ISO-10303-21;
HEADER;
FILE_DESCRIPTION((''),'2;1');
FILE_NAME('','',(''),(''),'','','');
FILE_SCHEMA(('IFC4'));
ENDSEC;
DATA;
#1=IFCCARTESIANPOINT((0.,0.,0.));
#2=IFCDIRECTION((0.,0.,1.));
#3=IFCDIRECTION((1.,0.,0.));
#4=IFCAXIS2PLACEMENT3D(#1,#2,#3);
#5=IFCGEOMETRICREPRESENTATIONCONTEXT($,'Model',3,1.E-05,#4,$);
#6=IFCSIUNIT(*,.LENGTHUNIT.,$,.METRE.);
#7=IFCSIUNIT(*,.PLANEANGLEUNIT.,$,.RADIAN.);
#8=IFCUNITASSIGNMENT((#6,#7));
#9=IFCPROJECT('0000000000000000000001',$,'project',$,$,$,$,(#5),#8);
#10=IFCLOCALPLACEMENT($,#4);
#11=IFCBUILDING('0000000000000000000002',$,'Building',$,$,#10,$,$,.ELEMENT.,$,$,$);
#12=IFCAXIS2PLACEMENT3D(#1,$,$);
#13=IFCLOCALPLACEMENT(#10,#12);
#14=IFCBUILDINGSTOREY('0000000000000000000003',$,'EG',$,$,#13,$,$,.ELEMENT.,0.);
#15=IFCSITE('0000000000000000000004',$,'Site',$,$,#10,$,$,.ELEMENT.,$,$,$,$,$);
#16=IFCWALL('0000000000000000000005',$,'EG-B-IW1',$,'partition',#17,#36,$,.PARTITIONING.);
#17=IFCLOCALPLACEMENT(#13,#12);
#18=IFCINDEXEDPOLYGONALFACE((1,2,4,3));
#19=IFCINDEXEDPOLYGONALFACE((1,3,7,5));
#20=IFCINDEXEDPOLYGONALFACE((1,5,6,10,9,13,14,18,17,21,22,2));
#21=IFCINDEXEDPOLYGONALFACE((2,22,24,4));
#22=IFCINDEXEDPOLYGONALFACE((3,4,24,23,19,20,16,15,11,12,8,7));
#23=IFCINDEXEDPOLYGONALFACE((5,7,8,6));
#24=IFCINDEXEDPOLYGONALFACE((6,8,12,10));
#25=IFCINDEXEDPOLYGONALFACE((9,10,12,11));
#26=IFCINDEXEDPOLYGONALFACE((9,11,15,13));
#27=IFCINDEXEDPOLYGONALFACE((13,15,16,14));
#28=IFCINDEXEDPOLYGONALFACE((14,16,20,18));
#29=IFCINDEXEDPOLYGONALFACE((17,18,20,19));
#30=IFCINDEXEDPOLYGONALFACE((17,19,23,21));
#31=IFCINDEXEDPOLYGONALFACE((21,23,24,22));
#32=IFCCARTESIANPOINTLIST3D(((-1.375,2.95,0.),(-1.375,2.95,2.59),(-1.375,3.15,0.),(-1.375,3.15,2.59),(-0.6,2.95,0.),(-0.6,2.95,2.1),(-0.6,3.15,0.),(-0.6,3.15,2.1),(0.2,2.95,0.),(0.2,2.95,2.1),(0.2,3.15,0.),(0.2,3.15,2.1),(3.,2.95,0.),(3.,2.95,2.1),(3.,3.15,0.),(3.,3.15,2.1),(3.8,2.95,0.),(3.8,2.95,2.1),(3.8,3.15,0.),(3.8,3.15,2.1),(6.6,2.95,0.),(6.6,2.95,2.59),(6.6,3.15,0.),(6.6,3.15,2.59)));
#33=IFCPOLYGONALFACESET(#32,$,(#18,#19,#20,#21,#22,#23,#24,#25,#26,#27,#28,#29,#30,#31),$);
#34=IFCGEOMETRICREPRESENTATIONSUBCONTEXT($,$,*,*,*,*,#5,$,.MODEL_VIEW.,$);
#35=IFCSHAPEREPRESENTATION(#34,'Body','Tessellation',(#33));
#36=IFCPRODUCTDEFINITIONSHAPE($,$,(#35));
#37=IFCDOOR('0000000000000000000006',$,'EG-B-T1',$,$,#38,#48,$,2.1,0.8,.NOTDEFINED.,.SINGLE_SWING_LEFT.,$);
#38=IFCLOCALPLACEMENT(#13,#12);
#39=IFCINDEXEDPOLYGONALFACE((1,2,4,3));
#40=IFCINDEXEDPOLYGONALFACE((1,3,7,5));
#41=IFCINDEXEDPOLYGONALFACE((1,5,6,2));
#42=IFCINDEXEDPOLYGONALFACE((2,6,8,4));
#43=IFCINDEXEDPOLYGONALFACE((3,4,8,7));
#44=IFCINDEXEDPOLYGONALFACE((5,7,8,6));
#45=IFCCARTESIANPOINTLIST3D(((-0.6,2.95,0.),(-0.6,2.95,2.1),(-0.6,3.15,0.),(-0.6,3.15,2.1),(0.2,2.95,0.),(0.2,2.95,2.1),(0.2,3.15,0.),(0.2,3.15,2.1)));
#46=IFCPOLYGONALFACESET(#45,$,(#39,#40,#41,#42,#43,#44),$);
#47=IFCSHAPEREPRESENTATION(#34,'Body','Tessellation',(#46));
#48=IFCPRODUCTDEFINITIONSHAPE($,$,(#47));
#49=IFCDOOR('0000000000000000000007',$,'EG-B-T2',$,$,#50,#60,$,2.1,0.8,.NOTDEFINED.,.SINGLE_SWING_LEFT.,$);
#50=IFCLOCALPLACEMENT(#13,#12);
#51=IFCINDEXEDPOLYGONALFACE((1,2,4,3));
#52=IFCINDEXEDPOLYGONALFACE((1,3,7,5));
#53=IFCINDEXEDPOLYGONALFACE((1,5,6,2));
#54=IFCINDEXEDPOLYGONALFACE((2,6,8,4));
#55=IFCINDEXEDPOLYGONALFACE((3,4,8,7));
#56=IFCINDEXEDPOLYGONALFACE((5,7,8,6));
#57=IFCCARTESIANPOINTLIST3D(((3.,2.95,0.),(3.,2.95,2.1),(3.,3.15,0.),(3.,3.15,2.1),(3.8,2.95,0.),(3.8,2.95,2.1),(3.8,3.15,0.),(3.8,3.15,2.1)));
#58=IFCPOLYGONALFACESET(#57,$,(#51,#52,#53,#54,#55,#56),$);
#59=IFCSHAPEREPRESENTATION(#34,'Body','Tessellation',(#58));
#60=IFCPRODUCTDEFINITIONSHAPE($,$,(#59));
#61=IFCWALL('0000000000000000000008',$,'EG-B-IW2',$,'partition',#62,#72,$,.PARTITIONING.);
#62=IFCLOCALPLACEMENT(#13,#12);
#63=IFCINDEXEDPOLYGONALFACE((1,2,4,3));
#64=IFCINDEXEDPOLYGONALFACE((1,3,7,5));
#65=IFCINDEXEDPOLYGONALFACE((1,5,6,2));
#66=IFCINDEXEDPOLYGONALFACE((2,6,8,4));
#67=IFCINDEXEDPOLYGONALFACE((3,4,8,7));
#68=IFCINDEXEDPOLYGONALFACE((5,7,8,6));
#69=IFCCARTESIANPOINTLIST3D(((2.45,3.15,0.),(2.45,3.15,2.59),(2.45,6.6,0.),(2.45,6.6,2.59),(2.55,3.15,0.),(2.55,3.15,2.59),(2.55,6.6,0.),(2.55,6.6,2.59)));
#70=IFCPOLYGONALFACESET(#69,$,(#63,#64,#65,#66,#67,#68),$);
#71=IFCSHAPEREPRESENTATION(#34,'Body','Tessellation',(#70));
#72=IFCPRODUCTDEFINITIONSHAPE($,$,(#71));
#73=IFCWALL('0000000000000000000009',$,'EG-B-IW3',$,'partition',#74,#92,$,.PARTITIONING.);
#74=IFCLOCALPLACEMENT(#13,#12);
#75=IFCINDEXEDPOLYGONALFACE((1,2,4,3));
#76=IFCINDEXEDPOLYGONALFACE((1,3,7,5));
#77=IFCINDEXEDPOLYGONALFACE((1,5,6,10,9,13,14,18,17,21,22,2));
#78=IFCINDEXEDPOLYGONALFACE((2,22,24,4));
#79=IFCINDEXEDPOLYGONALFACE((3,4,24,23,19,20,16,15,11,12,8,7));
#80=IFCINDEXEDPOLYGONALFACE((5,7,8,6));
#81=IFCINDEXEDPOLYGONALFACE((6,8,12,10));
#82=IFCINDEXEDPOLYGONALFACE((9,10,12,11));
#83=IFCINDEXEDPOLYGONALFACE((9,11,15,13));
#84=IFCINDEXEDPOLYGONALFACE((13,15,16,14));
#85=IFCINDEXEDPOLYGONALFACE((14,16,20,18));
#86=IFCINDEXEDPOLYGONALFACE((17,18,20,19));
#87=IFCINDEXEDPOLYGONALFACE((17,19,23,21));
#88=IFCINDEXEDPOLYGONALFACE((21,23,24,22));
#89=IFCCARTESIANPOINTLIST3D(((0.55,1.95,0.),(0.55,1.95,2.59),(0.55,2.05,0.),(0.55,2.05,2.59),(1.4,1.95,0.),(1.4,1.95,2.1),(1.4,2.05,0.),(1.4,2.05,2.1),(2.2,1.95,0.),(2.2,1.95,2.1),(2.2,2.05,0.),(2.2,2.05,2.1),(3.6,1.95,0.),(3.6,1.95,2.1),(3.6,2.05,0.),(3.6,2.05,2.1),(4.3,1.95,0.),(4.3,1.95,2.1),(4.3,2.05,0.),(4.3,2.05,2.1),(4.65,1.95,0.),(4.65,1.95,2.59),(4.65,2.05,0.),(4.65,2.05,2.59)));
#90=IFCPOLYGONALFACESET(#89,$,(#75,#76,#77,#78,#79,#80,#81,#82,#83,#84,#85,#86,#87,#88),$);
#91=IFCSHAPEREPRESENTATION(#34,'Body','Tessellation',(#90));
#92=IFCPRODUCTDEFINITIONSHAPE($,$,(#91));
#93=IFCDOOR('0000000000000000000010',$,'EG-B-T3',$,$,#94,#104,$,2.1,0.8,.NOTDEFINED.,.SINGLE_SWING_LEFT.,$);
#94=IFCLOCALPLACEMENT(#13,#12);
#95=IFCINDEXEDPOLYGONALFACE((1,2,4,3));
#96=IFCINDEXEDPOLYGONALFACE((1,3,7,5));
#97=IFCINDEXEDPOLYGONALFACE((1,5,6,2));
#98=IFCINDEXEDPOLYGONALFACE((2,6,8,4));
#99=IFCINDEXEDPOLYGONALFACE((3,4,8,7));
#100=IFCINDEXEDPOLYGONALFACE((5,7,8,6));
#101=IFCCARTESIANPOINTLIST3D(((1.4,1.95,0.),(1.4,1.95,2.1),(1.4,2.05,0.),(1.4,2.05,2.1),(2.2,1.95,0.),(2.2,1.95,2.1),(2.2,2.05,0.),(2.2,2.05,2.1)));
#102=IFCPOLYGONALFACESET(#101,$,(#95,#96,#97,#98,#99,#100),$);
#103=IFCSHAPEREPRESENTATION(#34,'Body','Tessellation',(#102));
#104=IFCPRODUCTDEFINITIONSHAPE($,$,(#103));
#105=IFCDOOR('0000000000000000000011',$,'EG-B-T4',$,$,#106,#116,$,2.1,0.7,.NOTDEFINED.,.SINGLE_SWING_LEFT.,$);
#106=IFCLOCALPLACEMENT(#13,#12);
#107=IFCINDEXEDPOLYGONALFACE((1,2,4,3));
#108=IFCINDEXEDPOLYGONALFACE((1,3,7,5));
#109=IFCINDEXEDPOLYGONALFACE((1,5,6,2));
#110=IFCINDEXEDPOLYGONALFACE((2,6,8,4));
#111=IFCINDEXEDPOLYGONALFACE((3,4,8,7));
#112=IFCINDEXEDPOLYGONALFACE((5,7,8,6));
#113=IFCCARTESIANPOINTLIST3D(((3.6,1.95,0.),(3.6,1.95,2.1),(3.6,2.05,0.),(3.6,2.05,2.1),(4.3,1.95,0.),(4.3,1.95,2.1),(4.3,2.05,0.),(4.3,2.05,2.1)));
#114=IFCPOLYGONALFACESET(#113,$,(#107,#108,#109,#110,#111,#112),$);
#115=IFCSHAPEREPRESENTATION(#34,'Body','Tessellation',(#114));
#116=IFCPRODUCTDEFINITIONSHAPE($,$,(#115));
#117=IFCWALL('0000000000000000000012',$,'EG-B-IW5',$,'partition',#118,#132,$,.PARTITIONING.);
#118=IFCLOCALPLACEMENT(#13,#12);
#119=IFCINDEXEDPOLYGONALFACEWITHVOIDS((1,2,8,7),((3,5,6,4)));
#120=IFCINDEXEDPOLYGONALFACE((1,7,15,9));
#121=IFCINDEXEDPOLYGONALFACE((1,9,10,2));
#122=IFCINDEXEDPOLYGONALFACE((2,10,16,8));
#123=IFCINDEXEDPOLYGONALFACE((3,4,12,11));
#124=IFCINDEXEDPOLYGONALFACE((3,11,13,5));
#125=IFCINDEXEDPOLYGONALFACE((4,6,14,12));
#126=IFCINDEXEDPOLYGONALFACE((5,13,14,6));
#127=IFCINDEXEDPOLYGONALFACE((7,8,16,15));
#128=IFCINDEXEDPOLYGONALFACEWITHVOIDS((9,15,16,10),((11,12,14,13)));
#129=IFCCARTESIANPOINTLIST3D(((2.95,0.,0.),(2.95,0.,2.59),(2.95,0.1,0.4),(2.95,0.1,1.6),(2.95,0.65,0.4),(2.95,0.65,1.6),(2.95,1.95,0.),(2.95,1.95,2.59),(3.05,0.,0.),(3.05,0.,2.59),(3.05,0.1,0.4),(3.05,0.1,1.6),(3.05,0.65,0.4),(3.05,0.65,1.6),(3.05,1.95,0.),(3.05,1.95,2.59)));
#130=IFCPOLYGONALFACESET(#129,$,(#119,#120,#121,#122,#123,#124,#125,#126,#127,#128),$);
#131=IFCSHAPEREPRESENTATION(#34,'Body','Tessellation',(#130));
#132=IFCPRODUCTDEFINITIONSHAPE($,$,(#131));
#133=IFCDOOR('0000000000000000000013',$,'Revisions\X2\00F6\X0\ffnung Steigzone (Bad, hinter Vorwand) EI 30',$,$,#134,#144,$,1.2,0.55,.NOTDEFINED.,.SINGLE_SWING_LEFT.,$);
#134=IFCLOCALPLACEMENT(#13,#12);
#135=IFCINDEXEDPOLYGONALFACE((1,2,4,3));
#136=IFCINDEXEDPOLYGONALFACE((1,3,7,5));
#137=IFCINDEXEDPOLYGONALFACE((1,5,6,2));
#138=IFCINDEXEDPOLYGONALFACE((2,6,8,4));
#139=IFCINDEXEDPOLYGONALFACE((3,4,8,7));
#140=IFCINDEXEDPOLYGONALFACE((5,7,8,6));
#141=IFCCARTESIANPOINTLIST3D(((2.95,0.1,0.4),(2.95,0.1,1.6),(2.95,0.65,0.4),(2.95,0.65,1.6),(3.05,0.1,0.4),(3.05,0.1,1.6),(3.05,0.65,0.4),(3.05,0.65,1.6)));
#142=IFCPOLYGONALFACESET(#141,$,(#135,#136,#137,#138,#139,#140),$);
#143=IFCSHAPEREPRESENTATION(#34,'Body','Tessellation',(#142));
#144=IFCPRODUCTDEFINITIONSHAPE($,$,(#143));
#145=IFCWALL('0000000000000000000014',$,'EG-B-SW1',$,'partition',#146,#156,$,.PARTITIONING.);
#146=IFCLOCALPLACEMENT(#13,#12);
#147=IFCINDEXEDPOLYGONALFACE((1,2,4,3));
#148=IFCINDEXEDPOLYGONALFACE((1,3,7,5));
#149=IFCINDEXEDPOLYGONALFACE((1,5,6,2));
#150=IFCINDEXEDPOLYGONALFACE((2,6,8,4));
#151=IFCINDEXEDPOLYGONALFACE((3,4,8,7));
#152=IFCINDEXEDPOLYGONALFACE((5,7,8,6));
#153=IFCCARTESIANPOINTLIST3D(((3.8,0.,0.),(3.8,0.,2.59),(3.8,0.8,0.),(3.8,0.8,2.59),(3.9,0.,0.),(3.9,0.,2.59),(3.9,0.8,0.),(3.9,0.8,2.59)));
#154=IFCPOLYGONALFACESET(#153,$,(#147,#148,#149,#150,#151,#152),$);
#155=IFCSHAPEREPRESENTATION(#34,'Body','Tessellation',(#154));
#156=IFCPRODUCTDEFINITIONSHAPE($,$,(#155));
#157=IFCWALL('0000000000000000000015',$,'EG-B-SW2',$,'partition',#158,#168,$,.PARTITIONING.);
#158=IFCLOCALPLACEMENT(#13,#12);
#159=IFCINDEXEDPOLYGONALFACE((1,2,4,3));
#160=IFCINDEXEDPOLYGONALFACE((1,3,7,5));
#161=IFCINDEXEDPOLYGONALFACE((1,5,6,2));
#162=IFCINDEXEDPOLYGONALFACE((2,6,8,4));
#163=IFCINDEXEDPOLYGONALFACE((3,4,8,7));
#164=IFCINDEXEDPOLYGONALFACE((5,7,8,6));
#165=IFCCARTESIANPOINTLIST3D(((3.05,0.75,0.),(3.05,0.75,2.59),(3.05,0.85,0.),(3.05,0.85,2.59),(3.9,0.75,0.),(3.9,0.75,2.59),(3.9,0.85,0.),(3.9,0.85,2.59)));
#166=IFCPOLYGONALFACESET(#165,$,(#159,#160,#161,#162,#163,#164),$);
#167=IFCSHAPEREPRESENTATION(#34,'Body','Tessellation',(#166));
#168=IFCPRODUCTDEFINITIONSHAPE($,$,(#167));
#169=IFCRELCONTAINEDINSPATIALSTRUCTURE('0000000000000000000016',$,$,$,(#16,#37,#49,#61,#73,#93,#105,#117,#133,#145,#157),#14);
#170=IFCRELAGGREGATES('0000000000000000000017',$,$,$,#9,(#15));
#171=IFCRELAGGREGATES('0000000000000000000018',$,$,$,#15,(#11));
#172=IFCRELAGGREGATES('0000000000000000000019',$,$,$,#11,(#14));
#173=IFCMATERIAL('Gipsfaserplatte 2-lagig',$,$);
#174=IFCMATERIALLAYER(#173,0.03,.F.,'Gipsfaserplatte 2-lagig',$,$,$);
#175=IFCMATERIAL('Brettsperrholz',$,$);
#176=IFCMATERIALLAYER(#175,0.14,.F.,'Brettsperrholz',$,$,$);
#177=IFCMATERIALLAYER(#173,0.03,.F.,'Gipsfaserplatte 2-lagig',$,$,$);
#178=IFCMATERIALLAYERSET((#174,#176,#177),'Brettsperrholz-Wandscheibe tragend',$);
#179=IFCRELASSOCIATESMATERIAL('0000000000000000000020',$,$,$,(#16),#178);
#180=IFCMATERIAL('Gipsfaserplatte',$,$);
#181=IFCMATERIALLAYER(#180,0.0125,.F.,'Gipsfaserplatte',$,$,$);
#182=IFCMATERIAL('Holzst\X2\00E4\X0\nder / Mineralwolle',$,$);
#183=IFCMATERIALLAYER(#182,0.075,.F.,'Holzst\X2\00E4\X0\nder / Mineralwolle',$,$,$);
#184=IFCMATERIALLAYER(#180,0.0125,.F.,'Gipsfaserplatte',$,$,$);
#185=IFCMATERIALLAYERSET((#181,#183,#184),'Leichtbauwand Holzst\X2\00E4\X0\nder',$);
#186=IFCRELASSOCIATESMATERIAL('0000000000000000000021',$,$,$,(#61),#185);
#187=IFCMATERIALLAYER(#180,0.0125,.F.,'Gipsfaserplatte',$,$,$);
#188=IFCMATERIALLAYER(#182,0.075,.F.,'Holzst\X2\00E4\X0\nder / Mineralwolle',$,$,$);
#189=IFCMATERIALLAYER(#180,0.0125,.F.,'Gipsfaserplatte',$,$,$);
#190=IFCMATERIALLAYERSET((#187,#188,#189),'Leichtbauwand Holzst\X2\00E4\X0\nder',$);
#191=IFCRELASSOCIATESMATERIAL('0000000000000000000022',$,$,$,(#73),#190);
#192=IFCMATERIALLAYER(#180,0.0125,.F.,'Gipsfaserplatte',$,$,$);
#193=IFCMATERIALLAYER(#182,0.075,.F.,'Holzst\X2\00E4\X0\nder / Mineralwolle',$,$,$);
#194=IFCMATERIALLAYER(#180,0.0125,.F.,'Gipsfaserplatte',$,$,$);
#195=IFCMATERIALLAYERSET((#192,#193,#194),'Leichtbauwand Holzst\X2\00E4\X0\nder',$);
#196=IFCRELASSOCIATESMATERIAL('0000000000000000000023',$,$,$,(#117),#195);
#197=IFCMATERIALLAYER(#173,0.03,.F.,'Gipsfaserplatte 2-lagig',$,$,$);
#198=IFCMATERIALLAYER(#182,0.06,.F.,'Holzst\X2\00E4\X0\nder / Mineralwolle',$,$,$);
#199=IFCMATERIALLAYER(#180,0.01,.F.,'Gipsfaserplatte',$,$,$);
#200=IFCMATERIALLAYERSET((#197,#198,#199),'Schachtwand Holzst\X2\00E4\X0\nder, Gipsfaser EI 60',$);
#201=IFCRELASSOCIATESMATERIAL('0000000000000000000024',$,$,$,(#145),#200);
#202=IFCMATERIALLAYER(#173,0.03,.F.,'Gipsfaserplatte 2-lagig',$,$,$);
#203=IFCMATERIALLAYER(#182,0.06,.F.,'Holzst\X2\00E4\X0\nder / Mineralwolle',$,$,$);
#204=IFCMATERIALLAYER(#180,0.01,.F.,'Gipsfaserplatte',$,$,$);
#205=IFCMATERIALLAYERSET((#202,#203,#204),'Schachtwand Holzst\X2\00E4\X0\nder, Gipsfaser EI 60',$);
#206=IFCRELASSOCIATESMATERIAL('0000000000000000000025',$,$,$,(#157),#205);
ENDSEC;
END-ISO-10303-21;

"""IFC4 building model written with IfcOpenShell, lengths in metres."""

from ifc_helpers import new_model, si_unit, frame, frame_2d, origin, origin_with_axes, place, context, subcontext, project, spatial, rectangle, extrude, material, layer, layer_set, element, fill, save


model = new_model("IFC4")

# Units and contexts
model_context = context("Model", 3, precision=1e-05, world=origin_with_axes())
sub_context = subcontext(model_context, None, None, "MODEL_VIEW")
ifc_project = project(units=[si_unit("LENGTHUNIT", "METRE"), si_unit("PLANEANGLEUNIT", "RADIAN")], contexts=[model_context])

# Site, building, storey
placement = place(None, origin_with_axes())
site = spatial("IfcSite", under=ifc_project, at=placement, Name="Site", CompositionType="ELEMENT")
building = spatial("IfcBuilding", under=site, at=placement, Name="Building", CompositionType="ELEMENT")
storey_placement = place(placement, origin())
storey = spatial("IfcBuildingStorey", under=building, at=storey_placement, Name="EG", CompositionType="ELEMENT", Elevation=0.0)

# Shared definitions
ifc_material_1 = material(Name="Gipsfaserplatte")

# Wall, openings, doors
ifc_material_2 = material(Name="Gipsfaserplatte 2-lagig")
ifc_layer_1 = layer(ifc_material_2, 0.03, ventilated=False, Name="Gipsfaserplatte 2-lagig")
ifc_material_3 = material(Name="Brettsperrholz")
ifc_layer_2 = layer(ifc_material_3, 0.14, ventilated=False, Name="Brettsperrholz")
ifc_layer_3 = layer(ifc_material_2, 0.03, ventilated=False, Name="Gipsfaserplatte 2-lagig")
ifc_layer_set_1 = layer_set([ifc_layer_1, ifc_layer_2, ifc_layer_3], Name="Brettsperrholz-Wandscheibe tragend")
wall_1_placement = place(storey_placement, frame((-1.375, 3.05, 0.0), z_axis=(0.0, 0.0, 1.0), x_axis=(1.0, 0.0, 0.0)))
wall_1 = element("IfcWall", 1, at=wall_1_placement, inside=storey, material=ifc_layer_set_1, Name="EG-B-IW1", ObjectType="partition", PredefinedType="PARTITIONING", context=sub_context, shape_type="SweptSolid", body=[
    extrude(rectangle(XDim=7.975, YDim=0.2, at=frame_2d((3.9875, 0.0))), origin(), (0.0, 0.0, 1.0), 2.59),
])
opening_1_placement = place(wall_1_placement, frame((1.175, 0.15, 0.0), z_axis=(0.0, -1.0, 0.0), x_axis=(1.0, 0.0, 0.0)))
opening_1 = element("IfcOpeningElement", 2, at=opening_1_placement, cuts=wall_1, PredefinedType="OPENING", context=sub_context, shape_type="SweptSolid", body=[
    extrude(rectangle(XDim=0.8, YDim=2.1, at=frame_2d((0.0, 1.05))), origin(), (0.0, 0.0, 1.0), 0.3),
])
opening_2_placement = place(wall_1_placement, frame((4.775, 0.15, 0.0), z_axis=(0.0, -1.0, 0.0), x_axis=(1.0, 0.0, 0.0)))
opening_2 = element("IfcOpeningElement", 3, at=opening_2_placement, cuts=wall_1, PredefinedType="OPENING", context=sub_context, shape_type="SweptSolid", body=[
    extrude(rectangle(XDim=0.8, YDim=2.1, at=frame_2d((0.0, 1.05))), origin(), (0.0, 0.0, 1.0), 0.3),
])
door_1_placement = place(wall_1_placement, frame((1.175, 0.1, 0.0), z_axis=(0.0, -1.0, 0.0), x_axis=(1.0, 0.0, 0.0)))
door_1 = element("IfcDoor", 4, at=door_1_placement, inside=storey, Name="EG-B-T1", OperationType="SINGLE_SWING_LEFT", OverallHeight=2.1, OverallWidth=0.8, PredefinedType="NOTDEFINED", context=sub_context, shape_type="SweptSolid", body=[
    extrude(rectangle(XDim=0.8, YDim=2.1, at=frame_2d((0.0, 1.05))), origin(), (0.0, 0.0, 1.0), 0.2),
])
fill(opening_1, door_1)
door_2_placement = place(wall_1_placement, frame((4.775, 0.1, 0.0), z_axis=(0.0, -1.0, 0.0), x_axis=(1.0, 0.0, 0.0)))
door_2 = element("IfcDoor", 5, at=door_2_placement, inside=storey, Name="EG-B-T2", OperationType="SINGLE_SWING_LEFT", OverallHeight=2.1, OverallWidth=0.8, PredefinedType="NOTDEFINED", context=sub_context, shape_type="SweptSolid", body=[
    extrude(rectangle(XDim=0.8, YDim=2.1, at=frame_2d((0.0, 1.05))), origin(), (0.0, 0.0, 1.0), 0.2),
])
fill(opening_2, door_2)

# Wall
ifc_layer_4 = layer(ifc_material_1, 0.0125, ventilated=False, Name="Gipsfaserplatte")
ifc_material_4 = material(Name="Holzständer / Mineralwolle")
ifc_layer_5 = layer(ifc_material_4, 0.075, ventilated=False, Name="Holzständer / Mineralwolle")
ifc_layer_6 = layer(ifc_material_1, 0.0125, ventilated=False, Name="Gipsfaserplatte")
ifc_layer_set_2 = layer_set([ifc_layer_4, ifc_layer_5, ifc_layer_6], Name="Leichtbauwand Holzständer")
wall_2_placement = place(storey_placement, frame((2.5, 3.15, 0.0), z_axis=(0.0, 0.0, 1.0), x_axis=(0.0, 1.0, 0.0)))
element("IfcWall", 6, at=wall_2_placement, inside=storey, material=ifc_layer_set_2, Name="EG-B-IW2", ObjectType="partition", PredefinedType="PARTITIONING", context=sub_context, shape_type="SweptSolid", body=[
    extrude(rectangle(XDim=3.45, YDim=0.1, at=frame_2d((1.725, 0.0))), origin(), (0.0, 0.0, 1.0), 2.59),
])

# Wall, openings, doors
ifc_layer_7 = layer(ifc_material_1, 0.0125, ventilated=False, Name="Gipsfaserplatte")
ifc_layer_8 = layer(ifc_material_4, 0.075, ventilated=False, Name="Holzständer / Mineralwolle")
ifc_layer_9 = layer(ifc_material_1, 0.0125, ventilated=False, Name="Gipsfaserplatte")
ifc_layer_set_3 = layer_set([ifc_layer_7, ifc_layer_8, ifc_layer_9], Name="Leichtbauwand Holzständer")
wall_3_placement = place(storey_placement, frame((0.55, 2.0, 0.0), z_axis=(0.0, 0.0, 1.0), x_axis=(1.0, 0.0, 0.0)))
wall_3 = element("IfcWall", 7, at=wall_3_placement, inside=storey, material=ifc_layer_set_3, Name="EG-B-IW3", ObjectType="partition", PredefinedType="PARTITIONING", context=sub_context, shape_type="SweptSolid", body=[
    extrude(rectangle(XDim=4.1, YDim=0.1, at=frame_2d((2.05, 0.0))), origin(), (0.0, 0.0, 1.0), 2.59),
])
opening_3_placement = place(wall_3_placement, frame((1.25, 0.1, 0.0), z_axis=(0.0, -1.0, 0.0), x_axis=(1.0, 0.0, 0.0)))
opening_3 = element("IfcOpeningElement", 8, at=opening_3_placement, cuts=wall_3, PredefinedType="OPENING", context=sub_context, shape_type="SweptSolid", body=[
    extrude(rectangle(XDim=0.8, YDim=2.1, at=frame_2d((0.0, 1.05))), origin(), (0.0, 0.0, 1.0), 0.2),
])
opening_4_placement = place(wall_3_placement, frame((3.4, 0.1, 0.0), z_axis=(0.0, -1.0, 0.0), x_axis=(1.0, 0.0, 0.0)))
opening_4 = element("IfcOpeningElement", 9, at=opening_4_placement, cuts=wall_3, PredefinedType="OPENING", context=sub_context, shape_type="SweptSolid", body=[
    extrude(rectangle(XDim=0.7, YDim=2.1, at=frame_2d((0.0, 1.05))), origin(), (0.0, 0.0, 1.0), 0.2),
])
door_3_placement = place(wall_3_placement, frame((1.25, 0.05, 0.0), z_axis=(0.0, -1.0, 0.0), x_axis=(1.0, 0.0, 0.0)))
door_3 = element("IfcDoor", 10, at=door_3_placement, inside=storey, Name="EG-B-T3", OperationType="SINGLE_SWING_LEFT", OverallHeight=2.1, OverallWidth=0.8, PredefinedType="NOTDEFINED", context=sub_context, shape_type="SweptSolid", body=[
    extrude(rectangle(XDim=0.8, YDim=2.1, at=frame_2d((0.0, 1.05))), origin(), (0.0, 0.0, 1.0), 0.1),
])
fill(opening_3, door_3)
door_4_placement = place(wall_3_placement, frame((3.4, 0.05, 0.0), z_axis=(0.0, -1.0, 0.0), x_axis=(1.0, 0.0, 0.0)))
door_4 = element("IfcDoor", 11, at=door_4_placement, inside=storey, Name="EG-B-T4", OperationType="SINGLE_SWING_LEFT", OverallHeight=2.1, OverallWidth=0.7, PredefinedType="NOTDEFINED", context=sub_context, shape_type="SweptSolid", body=[
    extrude(rectangle(XDim=0.7, YDim=2.1, at=frame_2d((0.0, 1.05))), origin(), (0.0, 0.0, 1.0), 0.1),
])
fill(opening_4, door_4)

# Wall, opening, door
ifc_layer_10 = layer(ifc_material_1, 0.0125, ventilated=False, Name="Gipsfaserplatte")
ifc_layer_11 = layer(ifc_material_4, 0.075, ventilated=False, Name="Holzständer / Mineralwolle")
ifc_layer_12 = layer(ifc_material_1, 0.0125, ventilated=False, Name="Gipsfaserplatte")
ifc_layer_set_4 = layer_set([ifc_layer_10, ifc_layer_11, ifc_layer_12], Name="Leichtbauwand Holzständer")
wall_4_placement = place(storey_placement, frame((3.0, 0.0, 0.0), z_axis=(0.0, 0.0, 1.0), x_axis=(0.0, 1.0, 0.0)))
wall_4 = element("IfcWall", 12, at=wall_4_placement, inside=storey, material=ifc_layer_set_4, Name="EG-B-IW5", ObjectType="partition", PredefinedType="PARTITIONING", context=sub_context, shape_type="SweptSolid", body=[
    extrude(rectangle(XDim=1.95, YDim=0.1, at=frame_2d((0.975, 0.0))), origin(), (0.0, 0.0, 1.0), 2.59),
])
opening_5_placement = place(wall_4_placement, frame((0.375, 0.1, 0.4), z_axis=(0.0, -1.0, 0.0), x_axis=(1.0, 0.0, 0.0)))
opening_5 = element("IfcOpeningElement", 13, at=opening_5_placement, cuts=wall_4, PredefinedType="OPENING", context=sub_context, shape_type="SweptSolid", body=[
    extrude(rectangle(XDim=0.55, YDim=1.2, at=frame_2d((0.0, 0.6))), origin(), (0.0, 0.0, 1.0), 0.2),
])
door_5_placement = place(wall_4_placement, frame((0.375, 0.05, 0.4), z_axis=(0.0, -1.0, 0.0), x_axis=(1.0, 0.0, 0.0)))
door_5 = element("IfcDoor", 14, at=door_5_placement, inside=storey, Name="Revisionsöffnung Steigzone (Bad, hinter Vorwand) EI 30", OperationType="SINGLE_SWING_LEFT", OverallHeight=1.2, OverallWidth=0.55, PredefinedType="NOTDEFINED", context=sub_context, shape_type="SweptSolid", body=[
    extrude(rectangle(XDim=0.55, YDim=1.2, at=frame_2d((0.0, 0.6))), origin(), (0.0, 0.0, 1.0), 0.1),
])
fill(opening_5, door_5)

# Walls
ifc_layer_13 = layer(ifc_material_2, 0.03, ventilated=False, Name="Gipsfaserplatte 2-lagig")
ifc_layer_14 = layer(ifc_material_4, 0.06, ventilated=False, Name="Holzständer / Mineralwolle")
ifc_layer_15 = layer(ifc_material_1, 0.01, ventilated=False, Name="Gipsfaserplatte")
ifc_layer_set_5 = layer_set([ifc_layer_13, ifc_layer_14, ifc_layer_15], Name="Schachtwand Holzständer, Gipsfaser EI 60")
wall_5_placement = place(storey_placement, frame((3.85, 0.0, 0.0), z_axis=(0.0, 0.0, 1.0), x_axis=(0.0, 1.0, 0.0)))
element("IfcWall", 15, at=wall_5_placement, inside=storey, material=ifc_layer_set_5, Name="EG-B-SW1", ObjectType="partition", PredefinedType="PARTITIONING", context=sub_context, shape_type="SweptSolid", body=[
    extrude(rectangle(XDim=0.8, YDim=0.1, at=frame_2d((0.4, 0.0))), origin(), (0.0, 0.0, 1.0), 2.59),
])
ifc_layer_16 = layer(ifc_material_2, 0.03, ventilated=False, Name="Gipsfaserplatte 2-lagig")
ifc_layer_17 = layer(ifc_material_4, 0.06, ventilated=False, Name="Holzständer / Mineralwolle")
ifc_layer_18 = layer(ifc_material_1, 0.01, ventilated=False, Name="Gipsfaserplatte")
ifc_layer_set_6 = layer_set([ifc_layer_16, ifc_layer_17, ifc_layer_18], Name="Schachtwand Holzständer, Gipsfaser EI 60")
wall_6_placement = place(storey_placement, frame((3.05, 0.8, 0.0), z_axis=(0.0, 0.0, 1.0), x_axis=(1.0, 0.0, 0.0)))
element("IfcWall", 16, at=wall_6_placement, inside=storey, material=ifc_layer_set_6, Name="EG-B-SW2", ObjectType="partition", PredefinedType="PARTITIONING", context=sub_context, shape_type="SweptSolid", body=[
    extrude(rectangle(XDim=0.85, YDim=0.1, at=frame_2d((0.425, 0.0))), origin(), (0.0, 0.0, 1.0), 2.59),
])

save(model, "model.ifc")
